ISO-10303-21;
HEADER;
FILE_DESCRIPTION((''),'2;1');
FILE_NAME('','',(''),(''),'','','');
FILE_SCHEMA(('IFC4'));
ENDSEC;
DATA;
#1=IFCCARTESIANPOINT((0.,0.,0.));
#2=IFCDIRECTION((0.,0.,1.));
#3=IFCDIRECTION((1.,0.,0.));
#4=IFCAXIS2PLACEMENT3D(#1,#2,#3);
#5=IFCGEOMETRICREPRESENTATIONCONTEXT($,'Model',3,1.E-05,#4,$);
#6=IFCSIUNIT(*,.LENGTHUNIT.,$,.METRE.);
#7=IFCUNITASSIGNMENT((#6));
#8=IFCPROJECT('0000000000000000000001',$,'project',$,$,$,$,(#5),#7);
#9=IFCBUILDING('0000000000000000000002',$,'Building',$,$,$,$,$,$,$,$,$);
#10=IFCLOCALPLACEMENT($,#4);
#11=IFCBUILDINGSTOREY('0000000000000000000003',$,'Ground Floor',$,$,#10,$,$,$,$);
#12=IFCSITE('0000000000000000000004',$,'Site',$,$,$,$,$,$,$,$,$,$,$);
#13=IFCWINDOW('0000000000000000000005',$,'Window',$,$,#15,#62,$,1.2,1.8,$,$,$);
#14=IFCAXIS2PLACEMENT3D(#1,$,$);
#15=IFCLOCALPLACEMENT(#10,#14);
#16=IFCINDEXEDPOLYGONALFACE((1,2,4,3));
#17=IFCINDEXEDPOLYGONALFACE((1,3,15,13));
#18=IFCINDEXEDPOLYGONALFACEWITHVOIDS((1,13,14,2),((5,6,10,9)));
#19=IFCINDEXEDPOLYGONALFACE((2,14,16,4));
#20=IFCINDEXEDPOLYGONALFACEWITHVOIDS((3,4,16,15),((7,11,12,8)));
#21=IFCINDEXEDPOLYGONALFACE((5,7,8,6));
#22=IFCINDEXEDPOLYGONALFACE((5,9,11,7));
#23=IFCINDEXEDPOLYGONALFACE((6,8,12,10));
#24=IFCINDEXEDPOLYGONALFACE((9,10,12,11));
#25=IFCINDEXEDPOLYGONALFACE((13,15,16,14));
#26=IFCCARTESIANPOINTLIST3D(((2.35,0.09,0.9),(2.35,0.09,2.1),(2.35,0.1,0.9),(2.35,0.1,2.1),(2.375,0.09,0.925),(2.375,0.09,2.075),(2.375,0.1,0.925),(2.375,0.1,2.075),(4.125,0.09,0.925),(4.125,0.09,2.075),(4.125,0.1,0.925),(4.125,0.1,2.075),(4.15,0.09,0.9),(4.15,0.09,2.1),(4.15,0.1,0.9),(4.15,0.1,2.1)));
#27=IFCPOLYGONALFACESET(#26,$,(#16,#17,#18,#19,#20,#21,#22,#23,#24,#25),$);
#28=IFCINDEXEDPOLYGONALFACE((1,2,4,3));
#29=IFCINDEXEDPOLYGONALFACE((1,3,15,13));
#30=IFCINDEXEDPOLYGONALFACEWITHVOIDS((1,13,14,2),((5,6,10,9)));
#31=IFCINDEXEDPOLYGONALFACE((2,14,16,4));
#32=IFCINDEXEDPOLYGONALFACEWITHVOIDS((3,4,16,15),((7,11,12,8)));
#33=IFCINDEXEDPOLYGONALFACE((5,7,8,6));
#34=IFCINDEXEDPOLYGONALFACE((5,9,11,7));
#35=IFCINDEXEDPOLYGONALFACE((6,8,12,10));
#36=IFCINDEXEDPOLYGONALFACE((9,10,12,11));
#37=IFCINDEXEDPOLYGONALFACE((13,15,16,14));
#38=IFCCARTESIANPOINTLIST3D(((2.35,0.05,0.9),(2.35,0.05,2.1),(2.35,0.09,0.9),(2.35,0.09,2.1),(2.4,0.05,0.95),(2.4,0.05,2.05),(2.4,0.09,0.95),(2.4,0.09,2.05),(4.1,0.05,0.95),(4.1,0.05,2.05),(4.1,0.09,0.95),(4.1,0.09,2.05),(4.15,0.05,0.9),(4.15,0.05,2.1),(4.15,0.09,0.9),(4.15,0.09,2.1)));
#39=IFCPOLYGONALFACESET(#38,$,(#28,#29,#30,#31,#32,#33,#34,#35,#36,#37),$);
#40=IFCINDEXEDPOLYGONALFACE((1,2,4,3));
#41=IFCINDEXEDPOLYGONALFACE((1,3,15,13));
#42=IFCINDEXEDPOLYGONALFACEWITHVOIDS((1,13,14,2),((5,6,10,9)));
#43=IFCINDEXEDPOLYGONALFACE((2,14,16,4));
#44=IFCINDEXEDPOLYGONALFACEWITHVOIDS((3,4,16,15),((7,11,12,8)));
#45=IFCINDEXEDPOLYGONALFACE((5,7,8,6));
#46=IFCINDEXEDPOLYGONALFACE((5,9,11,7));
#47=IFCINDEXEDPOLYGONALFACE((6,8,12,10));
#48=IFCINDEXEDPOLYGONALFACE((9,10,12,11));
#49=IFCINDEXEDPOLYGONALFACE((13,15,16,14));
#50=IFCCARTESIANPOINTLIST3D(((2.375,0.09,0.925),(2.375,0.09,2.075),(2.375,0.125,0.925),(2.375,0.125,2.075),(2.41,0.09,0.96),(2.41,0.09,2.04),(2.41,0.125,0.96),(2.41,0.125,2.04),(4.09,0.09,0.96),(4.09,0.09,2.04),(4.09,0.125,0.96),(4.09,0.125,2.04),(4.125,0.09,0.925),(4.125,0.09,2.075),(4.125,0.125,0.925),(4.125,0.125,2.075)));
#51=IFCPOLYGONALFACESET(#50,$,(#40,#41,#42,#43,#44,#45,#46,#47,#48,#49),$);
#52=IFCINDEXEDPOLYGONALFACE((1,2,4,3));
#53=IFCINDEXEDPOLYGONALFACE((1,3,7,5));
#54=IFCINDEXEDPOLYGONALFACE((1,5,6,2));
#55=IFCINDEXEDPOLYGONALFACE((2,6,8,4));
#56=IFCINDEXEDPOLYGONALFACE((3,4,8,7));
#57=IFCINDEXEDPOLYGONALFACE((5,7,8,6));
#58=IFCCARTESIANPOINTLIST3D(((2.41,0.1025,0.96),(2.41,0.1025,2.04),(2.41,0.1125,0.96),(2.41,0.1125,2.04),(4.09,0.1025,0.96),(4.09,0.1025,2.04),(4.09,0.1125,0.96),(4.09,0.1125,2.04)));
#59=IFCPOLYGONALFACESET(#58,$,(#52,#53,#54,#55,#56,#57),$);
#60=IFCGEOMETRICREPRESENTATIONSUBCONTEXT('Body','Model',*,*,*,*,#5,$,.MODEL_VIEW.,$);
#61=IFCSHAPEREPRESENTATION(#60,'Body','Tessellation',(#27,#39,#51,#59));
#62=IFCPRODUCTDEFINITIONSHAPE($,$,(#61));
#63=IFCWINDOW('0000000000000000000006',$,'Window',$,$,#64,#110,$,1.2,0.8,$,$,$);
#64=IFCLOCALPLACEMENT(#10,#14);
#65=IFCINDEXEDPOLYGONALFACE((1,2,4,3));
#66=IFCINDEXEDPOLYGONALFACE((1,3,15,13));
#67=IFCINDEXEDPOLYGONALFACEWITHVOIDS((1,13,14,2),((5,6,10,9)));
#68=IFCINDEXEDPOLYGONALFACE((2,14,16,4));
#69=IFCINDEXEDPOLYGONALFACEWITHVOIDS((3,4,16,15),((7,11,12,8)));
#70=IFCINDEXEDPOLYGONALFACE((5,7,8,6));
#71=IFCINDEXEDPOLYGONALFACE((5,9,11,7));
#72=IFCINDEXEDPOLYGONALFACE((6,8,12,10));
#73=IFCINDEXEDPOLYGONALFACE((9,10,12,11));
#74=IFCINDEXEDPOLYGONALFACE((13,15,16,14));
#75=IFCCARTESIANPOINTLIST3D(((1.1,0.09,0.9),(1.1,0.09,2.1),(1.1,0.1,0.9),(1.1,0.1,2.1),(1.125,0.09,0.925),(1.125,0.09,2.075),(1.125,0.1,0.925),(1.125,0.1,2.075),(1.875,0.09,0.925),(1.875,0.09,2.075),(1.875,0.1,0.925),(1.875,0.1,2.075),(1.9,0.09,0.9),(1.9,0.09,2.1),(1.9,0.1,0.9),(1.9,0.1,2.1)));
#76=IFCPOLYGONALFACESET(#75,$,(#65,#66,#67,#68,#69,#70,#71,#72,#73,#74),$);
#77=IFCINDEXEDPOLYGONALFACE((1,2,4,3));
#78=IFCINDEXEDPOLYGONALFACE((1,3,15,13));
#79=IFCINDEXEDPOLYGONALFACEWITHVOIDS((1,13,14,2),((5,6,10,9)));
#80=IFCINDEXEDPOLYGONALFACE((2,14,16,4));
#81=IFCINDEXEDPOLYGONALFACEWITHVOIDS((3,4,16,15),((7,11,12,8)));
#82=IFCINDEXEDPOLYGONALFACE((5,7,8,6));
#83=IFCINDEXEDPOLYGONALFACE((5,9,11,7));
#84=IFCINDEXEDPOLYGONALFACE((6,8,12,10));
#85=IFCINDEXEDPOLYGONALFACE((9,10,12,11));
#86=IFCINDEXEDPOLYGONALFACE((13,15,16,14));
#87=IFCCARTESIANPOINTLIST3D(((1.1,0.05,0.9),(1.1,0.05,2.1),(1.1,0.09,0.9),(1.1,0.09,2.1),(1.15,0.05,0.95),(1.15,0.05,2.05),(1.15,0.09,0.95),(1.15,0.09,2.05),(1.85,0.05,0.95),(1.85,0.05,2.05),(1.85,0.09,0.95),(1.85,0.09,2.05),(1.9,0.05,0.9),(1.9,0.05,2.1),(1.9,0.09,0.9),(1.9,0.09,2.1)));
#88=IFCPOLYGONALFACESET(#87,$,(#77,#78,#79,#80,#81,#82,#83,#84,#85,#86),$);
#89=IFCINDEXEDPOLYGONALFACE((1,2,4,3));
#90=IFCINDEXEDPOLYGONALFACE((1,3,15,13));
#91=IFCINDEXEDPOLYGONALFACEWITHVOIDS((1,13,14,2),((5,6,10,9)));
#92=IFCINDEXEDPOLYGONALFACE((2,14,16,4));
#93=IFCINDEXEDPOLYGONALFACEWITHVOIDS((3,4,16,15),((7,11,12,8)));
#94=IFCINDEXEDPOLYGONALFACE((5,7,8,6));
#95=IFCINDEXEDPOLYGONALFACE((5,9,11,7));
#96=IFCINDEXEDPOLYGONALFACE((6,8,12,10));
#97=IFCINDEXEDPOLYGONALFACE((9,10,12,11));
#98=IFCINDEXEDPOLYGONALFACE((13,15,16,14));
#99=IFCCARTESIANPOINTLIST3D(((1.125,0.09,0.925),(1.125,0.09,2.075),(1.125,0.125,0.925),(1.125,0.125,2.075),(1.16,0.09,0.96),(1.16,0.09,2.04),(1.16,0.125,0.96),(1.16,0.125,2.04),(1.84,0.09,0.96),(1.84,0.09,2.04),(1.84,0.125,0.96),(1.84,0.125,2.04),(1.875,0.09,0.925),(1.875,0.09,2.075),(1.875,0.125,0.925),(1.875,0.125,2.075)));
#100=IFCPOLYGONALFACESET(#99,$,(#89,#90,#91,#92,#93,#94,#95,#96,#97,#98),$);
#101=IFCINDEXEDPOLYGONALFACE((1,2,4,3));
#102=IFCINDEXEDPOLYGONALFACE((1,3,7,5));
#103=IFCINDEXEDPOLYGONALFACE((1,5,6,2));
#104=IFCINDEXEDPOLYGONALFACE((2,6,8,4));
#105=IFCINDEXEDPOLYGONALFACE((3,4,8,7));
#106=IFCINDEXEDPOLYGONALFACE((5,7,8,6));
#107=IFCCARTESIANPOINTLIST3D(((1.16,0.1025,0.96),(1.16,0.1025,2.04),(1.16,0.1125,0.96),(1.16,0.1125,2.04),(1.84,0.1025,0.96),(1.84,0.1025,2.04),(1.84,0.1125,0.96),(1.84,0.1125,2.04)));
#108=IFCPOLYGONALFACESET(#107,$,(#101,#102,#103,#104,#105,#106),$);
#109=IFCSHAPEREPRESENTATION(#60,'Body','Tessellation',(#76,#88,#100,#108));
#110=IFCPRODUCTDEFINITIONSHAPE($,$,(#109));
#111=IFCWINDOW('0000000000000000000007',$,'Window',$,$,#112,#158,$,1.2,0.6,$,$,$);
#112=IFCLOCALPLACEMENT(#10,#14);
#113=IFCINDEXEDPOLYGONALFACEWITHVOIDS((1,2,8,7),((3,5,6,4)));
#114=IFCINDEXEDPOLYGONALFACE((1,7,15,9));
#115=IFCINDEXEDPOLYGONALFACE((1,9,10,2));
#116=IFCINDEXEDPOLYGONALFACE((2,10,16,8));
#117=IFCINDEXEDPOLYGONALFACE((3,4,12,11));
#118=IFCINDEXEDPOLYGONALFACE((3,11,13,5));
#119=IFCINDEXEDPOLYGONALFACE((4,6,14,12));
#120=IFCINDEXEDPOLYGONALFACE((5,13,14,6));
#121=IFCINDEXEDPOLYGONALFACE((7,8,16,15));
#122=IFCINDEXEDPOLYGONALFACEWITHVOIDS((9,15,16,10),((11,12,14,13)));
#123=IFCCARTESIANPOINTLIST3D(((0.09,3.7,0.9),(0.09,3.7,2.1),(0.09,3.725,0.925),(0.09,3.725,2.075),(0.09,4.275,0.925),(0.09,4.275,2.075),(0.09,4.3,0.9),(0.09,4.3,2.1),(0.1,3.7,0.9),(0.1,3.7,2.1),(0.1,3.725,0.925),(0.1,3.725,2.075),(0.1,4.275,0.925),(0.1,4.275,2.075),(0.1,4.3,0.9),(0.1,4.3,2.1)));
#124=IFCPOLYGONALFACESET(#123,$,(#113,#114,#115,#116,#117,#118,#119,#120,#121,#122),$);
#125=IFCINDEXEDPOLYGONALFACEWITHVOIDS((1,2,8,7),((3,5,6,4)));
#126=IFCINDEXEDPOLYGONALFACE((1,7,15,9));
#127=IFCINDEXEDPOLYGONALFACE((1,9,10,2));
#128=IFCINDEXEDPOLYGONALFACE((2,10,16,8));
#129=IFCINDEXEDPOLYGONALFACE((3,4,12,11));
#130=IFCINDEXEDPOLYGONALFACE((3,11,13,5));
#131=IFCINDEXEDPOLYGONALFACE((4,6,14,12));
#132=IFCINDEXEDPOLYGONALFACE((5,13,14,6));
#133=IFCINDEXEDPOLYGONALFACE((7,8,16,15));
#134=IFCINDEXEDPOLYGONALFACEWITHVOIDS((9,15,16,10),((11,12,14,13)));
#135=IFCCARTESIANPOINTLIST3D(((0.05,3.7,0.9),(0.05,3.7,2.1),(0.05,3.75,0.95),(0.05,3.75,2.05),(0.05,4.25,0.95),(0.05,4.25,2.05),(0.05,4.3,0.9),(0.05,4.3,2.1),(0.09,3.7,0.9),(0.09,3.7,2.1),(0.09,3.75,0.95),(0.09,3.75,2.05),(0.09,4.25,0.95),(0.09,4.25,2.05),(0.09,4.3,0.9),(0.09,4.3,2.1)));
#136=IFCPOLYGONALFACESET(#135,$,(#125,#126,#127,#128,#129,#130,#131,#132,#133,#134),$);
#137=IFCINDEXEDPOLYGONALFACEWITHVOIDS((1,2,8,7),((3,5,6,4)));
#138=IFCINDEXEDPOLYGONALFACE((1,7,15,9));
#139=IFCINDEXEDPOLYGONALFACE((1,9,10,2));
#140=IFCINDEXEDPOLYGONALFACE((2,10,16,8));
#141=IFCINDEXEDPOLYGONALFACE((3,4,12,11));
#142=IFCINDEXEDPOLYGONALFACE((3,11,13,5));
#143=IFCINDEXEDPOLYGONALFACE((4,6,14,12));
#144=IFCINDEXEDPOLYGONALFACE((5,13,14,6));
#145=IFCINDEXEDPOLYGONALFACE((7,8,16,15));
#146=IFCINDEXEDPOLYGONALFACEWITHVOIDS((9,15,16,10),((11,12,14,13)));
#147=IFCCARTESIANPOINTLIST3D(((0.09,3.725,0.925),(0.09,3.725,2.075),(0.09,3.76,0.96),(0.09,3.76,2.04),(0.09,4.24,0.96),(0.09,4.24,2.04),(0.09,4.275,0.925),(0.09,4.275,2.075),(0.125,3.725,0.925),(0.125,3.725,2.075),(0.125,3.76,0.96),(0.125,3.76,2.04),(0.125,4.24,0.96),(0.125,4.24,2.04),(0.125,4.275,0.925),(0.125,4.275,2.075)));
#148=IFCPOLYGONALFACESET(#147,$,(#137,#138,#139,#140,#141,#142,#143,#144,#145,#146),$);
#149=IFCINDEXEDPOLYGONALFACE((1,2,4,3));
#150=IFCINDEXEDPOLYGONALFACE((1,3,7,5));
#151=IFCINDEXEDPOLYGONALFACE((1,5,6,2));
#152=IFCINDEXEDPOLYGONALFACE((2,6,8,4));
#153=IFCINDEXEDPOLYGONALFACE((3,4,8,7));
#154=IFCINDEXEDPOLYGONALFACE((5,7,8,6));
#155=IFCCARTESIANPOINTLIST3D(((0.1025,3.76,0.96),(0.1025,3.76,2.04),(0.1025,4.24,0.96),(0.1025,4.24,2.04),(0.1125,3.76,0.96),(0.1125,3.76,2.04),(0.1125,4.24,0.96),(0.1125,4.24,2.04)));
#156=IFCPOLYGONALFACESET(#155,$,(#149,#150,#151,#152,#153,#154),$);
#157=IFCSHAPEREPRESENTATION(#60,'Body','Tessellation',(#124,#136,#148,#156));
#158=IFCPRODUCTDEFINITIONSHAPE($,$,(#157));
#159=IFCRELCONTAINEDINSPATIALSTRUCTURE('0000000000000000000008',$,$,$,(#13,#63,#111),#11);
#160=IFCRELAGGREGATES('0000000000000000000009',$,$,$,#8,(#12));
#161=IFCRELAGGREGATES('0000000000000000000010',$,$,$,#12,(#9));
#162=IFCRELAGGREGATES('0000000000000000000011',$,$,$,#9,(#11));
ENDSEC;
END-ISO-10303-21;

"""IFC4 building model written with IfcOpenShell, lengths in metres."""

from ifc_helpers import new_model, si_unit, frame, origin_with_axes, place, context, subcontext, project, spatial, line, indexed_curve, outline, extrude, element, save


model = new_model("IFC4")

# Units and contexts
model_context = context("Model", 3, precision=1e-05, world=origin_with_axes())
body_context = subcontext(model_context, "Body", "Model", "MODEL_VIEW")
ifc_project = project(units=[si_unit("LENGTHUNIT", "METRE")], contexts=[model_context])

# Site, building, storey
site = spatial("IfcSite", under=ifc_project, Name="Site")
building = spatial("IfcBuilding", under=site, Name="Building")
storey_placement = place(None, origin_with_axes())
storey = spatial("IfcBuildingStorey", under=building, at=storey_placement, Name="Ground Floor")

# Windows
window_1_placement = place(storey_placement, frame((2.35, 0.0, 0.9), z_axis=(0.0, 0.0, 1.0), x_axis=(1.0, 0.0, 0.0)))
element("IfcWindow", 1, at=window_1_placement, inside=storey, Name="Window", OverallHeight=1.2, OverallWidth=1.8, context=body_context, shape_type="SweptSolid", body=[
    extrude(outline(indexed_curve([(0.0, 0.0), (1.8, 0.0), (1.8, 1.2), (0.0, 1.2)], segments=[line(1, 2, 3, 4, 1)]), holes=[indexed_curve([(0.025, 0.025), (1.775, 0.025), (1.775, 1.175), (0.025, 1.175)], segments=[line(1, 2, 3, 4, 1)])]), frame((0.0, 0.09, 0.0), z_axis=(0.0, -1.0, 0.0), x_axis=(1.0, 0.0, 0.0)), (0.0, 0.0, -1.0), 0.01),
    extrude(outline(indexed_curve([(0.0, 0.0), (1.8, 0.0), (1.8, 1.2), (0.0, 1.2)], segments=[line(1, 2, 3, 4, 1)]), holes=[indexed_curve([(0.05, 0.05), (1.75, 0.05), (1.75, 1.15), (0.05, 1.15)], segments=[line(1, 2, 3, 4, 1)])]), frame((0.0, 0.05, 0.0), z_axis=(0.0, -1.0, 0.0), x_axis=(1.0, 0.0, 0.0)), (0.0, 0.0, -1.0), 0.04),
    extrude(outline(indexed_curve([(0.0, 0.0), (1.75, 0.0), (1.75, 1.15), (0.0, 1.15)], segments=[line(1, 2, 3, 4, 1)]), holes=[indexed_curve([(0.035, 0.035), (1.715, 0.035), (1.715, 1.115), (0.035, 1.115)], segments=[line(1, 2, 3, 4, 1)])]), frame((0.025, 0.09, 0.025), z_axis=(0.0, -1.0, 0.0), x_axis=(1.0, 0.0, 0.0)), (0.0, 0.0, -1.0), 0.035),
    extrude(outline(indexed_curve([(0.035, 0.035), (1.715, 0.035), (1.715, 1.115), (0.035, 1.115)], segments=[line(1, 2, 3, 4, 1)])), frame((0.025, 0.1025, 0.025), z_axis=(0.0, -1.0, 0.0), x_axis=(1.0, 0.0, 0.0)), (0.0, 0.0, -1.0), 0.01),
])
window_2_placement = place(storey_placement, frame((1.1, 0.0, 0.9), z_axis=(0.0, 0.0, 1.0), x_axis=(1.0, 0.0, 0.0)))
element("IfcWindow", 2, at=window_2_placement, inside=storey, Name="Window", OverallHeight=1.2, OverallWidth=0.8, context=body_context, shape_type="SweptSolid", body=[
    extrude(outline(indexed_curve([(0.0, 0.0), (0.8, 0.0), (0.8, 1.2), (0.0, 1.2)], segments=[line(1, 2, 3, 4, 1)]), holes=[indexed_curve([(0.025, 0.025), (0.775, 0.025), (0.775, 1.175), (0.025, 1.175)], segments=[line(1, 2, 3, 4, 1)])]), frame((0.0, 0.09, 0.0), z_axis=(0.0, -1.0, 0.0), x_axis=(1.0, 0.0, 0.0)), (0.0, 0.0, -1.0), 0.01),
    extrude(outline(indexed_curve([(0.0, 0.0), (0.8, 0.0), (0.8, 1.2), (0.0, 1.2)], segments=[line(1, 2, 3, 4, 1)]), holes=[indexed_curve([(0.05, 0.05), (0.75, 0.05), (0.75, 1.15), (0.05, 1.15)], segments=[line(1, 2, 3, 4, 1)])]), frame((0.0, 0.05, 0.0), z_axis=(0.0, -1.0, 0.0), x_axis=(1.0, 0.0, 0.0)), (0.0, 0.0, -1.0), 0.04),
    extrude(outline(indexed_curve([(0.0, 0.0), (0.75, 0.0), (0.75, 1.15), (0.0, 1.15)], segments=[line(1, 2, 3, 4, 1)]), holes=[indexed_curve([(0.035, 0.035), (0.715, 0.035), (0.715, 1.115), (0.035, 1.115)], segments=[line(1, 2, 3, 4, 1)])]), frame((0.025, 0.09, 0.025), z_axis=(0.0, -1.0, 0.0), x_axis=(1.0, 0.0, 0.0)), (0.0, 0.0, -1.0), 0.035),
    extrude(outline(indexed_curve([(0.035, 0.035), (0.715, 0.035), (0.715, 1.115), (0.035, 1.115)], segments=[line(1, 2, 3, 4, 1)])), frame((0.025, 0.1025, 0.025), z_axis=(0.0, -1.0, 0.0), x_axis=(1.0, 0.0, 0.0)), (0.0, 0.0, -1.0), 0.01),
])
window_3_placement = place(storey_placement, frame((0.0, 4.3, 0.9), z_axis=(0.0, 0.0, 1.0), x_axis=(0.0, -1.0, 0.0)))
element("IfcWindow", 3, at=window_3_placement, inside=storey, Name="Window", OverallHeight=1.2, OverallWidth=0.6, context=body_context, shape_type="SweptSolid", body=[
    extrude(outline(indexed_curve([(0.0, 0.0), (0.6, 0.0), (0.6, 1.2), (0.0, 1.2)], segments=[line(1, 2, 3, 4, 1)]), holes=[indexed_curve([(0.025, 0.025), (0.575, 0.025), (0.575, 1.175), (0.025, 1.175)], segments=[line(1, 2, 3, 4, 1)])]), frame((0.0, 0.09, 0.0), z_axis=(0.0, -1.0, 0.0), x_axis=(1.0, 0.0, 0.0)), (0.0, 0.0, -1.0), 0.01),
    extrude(outline(indexed_curve([(0.0, 0.0), (0.6, 0.0), (0.6, 1.2), (0.0, 1.2)], segments=[line(1, 2, 3, 4, 1)]), holes=[indexed_curve([(0.05, 0.05), (0.55, 0.05), (0.55, 1.15), (0.05, 1.15)], segments=[line(1, 2, 3, 4, 1)])]), frame((0.0, 0.05, 0.0), z_axis=(0.0, -1.0, 0.0), x_axis=(1.0, 0.0, 0.0)), (0.0, 0.0, -1.0), 0.04),
    extrude(outline(indexed_curve([(0.0, 0.0), (0.55, 0.0), (0.55, 1.15), (0.0, 1.15)], segments=[line(1, 2, 3, 4, 1)]), holes=[indexed_curve([(0.035, 0.035), (0.515, 0.035), (0.515, 1.115), (0.035, 1.115)], segments=[line(1, 2, 3, 4, 1)])]), frame((0.025, 0.09, 0.025), z_axis=(0.0, -1.0, 0.0), x_axis=(1.0, 0.0, 0.0)), (0.0, 0.0, -1.0), 0.035),
    extrude(outline(indexed_curve([(0.035, 0.035), (0.515, 0.035), (0.515, 1.115), (0.035, 1.115)], segments=[line(1, 2, 3, 4, 1)])), frame((0.025, 0.1025, 0.025), z_axis=(0.0, -1.0, 0.0), x_axis=(1.0, 0.0, 0.0)), (0.0, 0.0, -1.0), 0.01),
])

save(model, "model.ifc")
